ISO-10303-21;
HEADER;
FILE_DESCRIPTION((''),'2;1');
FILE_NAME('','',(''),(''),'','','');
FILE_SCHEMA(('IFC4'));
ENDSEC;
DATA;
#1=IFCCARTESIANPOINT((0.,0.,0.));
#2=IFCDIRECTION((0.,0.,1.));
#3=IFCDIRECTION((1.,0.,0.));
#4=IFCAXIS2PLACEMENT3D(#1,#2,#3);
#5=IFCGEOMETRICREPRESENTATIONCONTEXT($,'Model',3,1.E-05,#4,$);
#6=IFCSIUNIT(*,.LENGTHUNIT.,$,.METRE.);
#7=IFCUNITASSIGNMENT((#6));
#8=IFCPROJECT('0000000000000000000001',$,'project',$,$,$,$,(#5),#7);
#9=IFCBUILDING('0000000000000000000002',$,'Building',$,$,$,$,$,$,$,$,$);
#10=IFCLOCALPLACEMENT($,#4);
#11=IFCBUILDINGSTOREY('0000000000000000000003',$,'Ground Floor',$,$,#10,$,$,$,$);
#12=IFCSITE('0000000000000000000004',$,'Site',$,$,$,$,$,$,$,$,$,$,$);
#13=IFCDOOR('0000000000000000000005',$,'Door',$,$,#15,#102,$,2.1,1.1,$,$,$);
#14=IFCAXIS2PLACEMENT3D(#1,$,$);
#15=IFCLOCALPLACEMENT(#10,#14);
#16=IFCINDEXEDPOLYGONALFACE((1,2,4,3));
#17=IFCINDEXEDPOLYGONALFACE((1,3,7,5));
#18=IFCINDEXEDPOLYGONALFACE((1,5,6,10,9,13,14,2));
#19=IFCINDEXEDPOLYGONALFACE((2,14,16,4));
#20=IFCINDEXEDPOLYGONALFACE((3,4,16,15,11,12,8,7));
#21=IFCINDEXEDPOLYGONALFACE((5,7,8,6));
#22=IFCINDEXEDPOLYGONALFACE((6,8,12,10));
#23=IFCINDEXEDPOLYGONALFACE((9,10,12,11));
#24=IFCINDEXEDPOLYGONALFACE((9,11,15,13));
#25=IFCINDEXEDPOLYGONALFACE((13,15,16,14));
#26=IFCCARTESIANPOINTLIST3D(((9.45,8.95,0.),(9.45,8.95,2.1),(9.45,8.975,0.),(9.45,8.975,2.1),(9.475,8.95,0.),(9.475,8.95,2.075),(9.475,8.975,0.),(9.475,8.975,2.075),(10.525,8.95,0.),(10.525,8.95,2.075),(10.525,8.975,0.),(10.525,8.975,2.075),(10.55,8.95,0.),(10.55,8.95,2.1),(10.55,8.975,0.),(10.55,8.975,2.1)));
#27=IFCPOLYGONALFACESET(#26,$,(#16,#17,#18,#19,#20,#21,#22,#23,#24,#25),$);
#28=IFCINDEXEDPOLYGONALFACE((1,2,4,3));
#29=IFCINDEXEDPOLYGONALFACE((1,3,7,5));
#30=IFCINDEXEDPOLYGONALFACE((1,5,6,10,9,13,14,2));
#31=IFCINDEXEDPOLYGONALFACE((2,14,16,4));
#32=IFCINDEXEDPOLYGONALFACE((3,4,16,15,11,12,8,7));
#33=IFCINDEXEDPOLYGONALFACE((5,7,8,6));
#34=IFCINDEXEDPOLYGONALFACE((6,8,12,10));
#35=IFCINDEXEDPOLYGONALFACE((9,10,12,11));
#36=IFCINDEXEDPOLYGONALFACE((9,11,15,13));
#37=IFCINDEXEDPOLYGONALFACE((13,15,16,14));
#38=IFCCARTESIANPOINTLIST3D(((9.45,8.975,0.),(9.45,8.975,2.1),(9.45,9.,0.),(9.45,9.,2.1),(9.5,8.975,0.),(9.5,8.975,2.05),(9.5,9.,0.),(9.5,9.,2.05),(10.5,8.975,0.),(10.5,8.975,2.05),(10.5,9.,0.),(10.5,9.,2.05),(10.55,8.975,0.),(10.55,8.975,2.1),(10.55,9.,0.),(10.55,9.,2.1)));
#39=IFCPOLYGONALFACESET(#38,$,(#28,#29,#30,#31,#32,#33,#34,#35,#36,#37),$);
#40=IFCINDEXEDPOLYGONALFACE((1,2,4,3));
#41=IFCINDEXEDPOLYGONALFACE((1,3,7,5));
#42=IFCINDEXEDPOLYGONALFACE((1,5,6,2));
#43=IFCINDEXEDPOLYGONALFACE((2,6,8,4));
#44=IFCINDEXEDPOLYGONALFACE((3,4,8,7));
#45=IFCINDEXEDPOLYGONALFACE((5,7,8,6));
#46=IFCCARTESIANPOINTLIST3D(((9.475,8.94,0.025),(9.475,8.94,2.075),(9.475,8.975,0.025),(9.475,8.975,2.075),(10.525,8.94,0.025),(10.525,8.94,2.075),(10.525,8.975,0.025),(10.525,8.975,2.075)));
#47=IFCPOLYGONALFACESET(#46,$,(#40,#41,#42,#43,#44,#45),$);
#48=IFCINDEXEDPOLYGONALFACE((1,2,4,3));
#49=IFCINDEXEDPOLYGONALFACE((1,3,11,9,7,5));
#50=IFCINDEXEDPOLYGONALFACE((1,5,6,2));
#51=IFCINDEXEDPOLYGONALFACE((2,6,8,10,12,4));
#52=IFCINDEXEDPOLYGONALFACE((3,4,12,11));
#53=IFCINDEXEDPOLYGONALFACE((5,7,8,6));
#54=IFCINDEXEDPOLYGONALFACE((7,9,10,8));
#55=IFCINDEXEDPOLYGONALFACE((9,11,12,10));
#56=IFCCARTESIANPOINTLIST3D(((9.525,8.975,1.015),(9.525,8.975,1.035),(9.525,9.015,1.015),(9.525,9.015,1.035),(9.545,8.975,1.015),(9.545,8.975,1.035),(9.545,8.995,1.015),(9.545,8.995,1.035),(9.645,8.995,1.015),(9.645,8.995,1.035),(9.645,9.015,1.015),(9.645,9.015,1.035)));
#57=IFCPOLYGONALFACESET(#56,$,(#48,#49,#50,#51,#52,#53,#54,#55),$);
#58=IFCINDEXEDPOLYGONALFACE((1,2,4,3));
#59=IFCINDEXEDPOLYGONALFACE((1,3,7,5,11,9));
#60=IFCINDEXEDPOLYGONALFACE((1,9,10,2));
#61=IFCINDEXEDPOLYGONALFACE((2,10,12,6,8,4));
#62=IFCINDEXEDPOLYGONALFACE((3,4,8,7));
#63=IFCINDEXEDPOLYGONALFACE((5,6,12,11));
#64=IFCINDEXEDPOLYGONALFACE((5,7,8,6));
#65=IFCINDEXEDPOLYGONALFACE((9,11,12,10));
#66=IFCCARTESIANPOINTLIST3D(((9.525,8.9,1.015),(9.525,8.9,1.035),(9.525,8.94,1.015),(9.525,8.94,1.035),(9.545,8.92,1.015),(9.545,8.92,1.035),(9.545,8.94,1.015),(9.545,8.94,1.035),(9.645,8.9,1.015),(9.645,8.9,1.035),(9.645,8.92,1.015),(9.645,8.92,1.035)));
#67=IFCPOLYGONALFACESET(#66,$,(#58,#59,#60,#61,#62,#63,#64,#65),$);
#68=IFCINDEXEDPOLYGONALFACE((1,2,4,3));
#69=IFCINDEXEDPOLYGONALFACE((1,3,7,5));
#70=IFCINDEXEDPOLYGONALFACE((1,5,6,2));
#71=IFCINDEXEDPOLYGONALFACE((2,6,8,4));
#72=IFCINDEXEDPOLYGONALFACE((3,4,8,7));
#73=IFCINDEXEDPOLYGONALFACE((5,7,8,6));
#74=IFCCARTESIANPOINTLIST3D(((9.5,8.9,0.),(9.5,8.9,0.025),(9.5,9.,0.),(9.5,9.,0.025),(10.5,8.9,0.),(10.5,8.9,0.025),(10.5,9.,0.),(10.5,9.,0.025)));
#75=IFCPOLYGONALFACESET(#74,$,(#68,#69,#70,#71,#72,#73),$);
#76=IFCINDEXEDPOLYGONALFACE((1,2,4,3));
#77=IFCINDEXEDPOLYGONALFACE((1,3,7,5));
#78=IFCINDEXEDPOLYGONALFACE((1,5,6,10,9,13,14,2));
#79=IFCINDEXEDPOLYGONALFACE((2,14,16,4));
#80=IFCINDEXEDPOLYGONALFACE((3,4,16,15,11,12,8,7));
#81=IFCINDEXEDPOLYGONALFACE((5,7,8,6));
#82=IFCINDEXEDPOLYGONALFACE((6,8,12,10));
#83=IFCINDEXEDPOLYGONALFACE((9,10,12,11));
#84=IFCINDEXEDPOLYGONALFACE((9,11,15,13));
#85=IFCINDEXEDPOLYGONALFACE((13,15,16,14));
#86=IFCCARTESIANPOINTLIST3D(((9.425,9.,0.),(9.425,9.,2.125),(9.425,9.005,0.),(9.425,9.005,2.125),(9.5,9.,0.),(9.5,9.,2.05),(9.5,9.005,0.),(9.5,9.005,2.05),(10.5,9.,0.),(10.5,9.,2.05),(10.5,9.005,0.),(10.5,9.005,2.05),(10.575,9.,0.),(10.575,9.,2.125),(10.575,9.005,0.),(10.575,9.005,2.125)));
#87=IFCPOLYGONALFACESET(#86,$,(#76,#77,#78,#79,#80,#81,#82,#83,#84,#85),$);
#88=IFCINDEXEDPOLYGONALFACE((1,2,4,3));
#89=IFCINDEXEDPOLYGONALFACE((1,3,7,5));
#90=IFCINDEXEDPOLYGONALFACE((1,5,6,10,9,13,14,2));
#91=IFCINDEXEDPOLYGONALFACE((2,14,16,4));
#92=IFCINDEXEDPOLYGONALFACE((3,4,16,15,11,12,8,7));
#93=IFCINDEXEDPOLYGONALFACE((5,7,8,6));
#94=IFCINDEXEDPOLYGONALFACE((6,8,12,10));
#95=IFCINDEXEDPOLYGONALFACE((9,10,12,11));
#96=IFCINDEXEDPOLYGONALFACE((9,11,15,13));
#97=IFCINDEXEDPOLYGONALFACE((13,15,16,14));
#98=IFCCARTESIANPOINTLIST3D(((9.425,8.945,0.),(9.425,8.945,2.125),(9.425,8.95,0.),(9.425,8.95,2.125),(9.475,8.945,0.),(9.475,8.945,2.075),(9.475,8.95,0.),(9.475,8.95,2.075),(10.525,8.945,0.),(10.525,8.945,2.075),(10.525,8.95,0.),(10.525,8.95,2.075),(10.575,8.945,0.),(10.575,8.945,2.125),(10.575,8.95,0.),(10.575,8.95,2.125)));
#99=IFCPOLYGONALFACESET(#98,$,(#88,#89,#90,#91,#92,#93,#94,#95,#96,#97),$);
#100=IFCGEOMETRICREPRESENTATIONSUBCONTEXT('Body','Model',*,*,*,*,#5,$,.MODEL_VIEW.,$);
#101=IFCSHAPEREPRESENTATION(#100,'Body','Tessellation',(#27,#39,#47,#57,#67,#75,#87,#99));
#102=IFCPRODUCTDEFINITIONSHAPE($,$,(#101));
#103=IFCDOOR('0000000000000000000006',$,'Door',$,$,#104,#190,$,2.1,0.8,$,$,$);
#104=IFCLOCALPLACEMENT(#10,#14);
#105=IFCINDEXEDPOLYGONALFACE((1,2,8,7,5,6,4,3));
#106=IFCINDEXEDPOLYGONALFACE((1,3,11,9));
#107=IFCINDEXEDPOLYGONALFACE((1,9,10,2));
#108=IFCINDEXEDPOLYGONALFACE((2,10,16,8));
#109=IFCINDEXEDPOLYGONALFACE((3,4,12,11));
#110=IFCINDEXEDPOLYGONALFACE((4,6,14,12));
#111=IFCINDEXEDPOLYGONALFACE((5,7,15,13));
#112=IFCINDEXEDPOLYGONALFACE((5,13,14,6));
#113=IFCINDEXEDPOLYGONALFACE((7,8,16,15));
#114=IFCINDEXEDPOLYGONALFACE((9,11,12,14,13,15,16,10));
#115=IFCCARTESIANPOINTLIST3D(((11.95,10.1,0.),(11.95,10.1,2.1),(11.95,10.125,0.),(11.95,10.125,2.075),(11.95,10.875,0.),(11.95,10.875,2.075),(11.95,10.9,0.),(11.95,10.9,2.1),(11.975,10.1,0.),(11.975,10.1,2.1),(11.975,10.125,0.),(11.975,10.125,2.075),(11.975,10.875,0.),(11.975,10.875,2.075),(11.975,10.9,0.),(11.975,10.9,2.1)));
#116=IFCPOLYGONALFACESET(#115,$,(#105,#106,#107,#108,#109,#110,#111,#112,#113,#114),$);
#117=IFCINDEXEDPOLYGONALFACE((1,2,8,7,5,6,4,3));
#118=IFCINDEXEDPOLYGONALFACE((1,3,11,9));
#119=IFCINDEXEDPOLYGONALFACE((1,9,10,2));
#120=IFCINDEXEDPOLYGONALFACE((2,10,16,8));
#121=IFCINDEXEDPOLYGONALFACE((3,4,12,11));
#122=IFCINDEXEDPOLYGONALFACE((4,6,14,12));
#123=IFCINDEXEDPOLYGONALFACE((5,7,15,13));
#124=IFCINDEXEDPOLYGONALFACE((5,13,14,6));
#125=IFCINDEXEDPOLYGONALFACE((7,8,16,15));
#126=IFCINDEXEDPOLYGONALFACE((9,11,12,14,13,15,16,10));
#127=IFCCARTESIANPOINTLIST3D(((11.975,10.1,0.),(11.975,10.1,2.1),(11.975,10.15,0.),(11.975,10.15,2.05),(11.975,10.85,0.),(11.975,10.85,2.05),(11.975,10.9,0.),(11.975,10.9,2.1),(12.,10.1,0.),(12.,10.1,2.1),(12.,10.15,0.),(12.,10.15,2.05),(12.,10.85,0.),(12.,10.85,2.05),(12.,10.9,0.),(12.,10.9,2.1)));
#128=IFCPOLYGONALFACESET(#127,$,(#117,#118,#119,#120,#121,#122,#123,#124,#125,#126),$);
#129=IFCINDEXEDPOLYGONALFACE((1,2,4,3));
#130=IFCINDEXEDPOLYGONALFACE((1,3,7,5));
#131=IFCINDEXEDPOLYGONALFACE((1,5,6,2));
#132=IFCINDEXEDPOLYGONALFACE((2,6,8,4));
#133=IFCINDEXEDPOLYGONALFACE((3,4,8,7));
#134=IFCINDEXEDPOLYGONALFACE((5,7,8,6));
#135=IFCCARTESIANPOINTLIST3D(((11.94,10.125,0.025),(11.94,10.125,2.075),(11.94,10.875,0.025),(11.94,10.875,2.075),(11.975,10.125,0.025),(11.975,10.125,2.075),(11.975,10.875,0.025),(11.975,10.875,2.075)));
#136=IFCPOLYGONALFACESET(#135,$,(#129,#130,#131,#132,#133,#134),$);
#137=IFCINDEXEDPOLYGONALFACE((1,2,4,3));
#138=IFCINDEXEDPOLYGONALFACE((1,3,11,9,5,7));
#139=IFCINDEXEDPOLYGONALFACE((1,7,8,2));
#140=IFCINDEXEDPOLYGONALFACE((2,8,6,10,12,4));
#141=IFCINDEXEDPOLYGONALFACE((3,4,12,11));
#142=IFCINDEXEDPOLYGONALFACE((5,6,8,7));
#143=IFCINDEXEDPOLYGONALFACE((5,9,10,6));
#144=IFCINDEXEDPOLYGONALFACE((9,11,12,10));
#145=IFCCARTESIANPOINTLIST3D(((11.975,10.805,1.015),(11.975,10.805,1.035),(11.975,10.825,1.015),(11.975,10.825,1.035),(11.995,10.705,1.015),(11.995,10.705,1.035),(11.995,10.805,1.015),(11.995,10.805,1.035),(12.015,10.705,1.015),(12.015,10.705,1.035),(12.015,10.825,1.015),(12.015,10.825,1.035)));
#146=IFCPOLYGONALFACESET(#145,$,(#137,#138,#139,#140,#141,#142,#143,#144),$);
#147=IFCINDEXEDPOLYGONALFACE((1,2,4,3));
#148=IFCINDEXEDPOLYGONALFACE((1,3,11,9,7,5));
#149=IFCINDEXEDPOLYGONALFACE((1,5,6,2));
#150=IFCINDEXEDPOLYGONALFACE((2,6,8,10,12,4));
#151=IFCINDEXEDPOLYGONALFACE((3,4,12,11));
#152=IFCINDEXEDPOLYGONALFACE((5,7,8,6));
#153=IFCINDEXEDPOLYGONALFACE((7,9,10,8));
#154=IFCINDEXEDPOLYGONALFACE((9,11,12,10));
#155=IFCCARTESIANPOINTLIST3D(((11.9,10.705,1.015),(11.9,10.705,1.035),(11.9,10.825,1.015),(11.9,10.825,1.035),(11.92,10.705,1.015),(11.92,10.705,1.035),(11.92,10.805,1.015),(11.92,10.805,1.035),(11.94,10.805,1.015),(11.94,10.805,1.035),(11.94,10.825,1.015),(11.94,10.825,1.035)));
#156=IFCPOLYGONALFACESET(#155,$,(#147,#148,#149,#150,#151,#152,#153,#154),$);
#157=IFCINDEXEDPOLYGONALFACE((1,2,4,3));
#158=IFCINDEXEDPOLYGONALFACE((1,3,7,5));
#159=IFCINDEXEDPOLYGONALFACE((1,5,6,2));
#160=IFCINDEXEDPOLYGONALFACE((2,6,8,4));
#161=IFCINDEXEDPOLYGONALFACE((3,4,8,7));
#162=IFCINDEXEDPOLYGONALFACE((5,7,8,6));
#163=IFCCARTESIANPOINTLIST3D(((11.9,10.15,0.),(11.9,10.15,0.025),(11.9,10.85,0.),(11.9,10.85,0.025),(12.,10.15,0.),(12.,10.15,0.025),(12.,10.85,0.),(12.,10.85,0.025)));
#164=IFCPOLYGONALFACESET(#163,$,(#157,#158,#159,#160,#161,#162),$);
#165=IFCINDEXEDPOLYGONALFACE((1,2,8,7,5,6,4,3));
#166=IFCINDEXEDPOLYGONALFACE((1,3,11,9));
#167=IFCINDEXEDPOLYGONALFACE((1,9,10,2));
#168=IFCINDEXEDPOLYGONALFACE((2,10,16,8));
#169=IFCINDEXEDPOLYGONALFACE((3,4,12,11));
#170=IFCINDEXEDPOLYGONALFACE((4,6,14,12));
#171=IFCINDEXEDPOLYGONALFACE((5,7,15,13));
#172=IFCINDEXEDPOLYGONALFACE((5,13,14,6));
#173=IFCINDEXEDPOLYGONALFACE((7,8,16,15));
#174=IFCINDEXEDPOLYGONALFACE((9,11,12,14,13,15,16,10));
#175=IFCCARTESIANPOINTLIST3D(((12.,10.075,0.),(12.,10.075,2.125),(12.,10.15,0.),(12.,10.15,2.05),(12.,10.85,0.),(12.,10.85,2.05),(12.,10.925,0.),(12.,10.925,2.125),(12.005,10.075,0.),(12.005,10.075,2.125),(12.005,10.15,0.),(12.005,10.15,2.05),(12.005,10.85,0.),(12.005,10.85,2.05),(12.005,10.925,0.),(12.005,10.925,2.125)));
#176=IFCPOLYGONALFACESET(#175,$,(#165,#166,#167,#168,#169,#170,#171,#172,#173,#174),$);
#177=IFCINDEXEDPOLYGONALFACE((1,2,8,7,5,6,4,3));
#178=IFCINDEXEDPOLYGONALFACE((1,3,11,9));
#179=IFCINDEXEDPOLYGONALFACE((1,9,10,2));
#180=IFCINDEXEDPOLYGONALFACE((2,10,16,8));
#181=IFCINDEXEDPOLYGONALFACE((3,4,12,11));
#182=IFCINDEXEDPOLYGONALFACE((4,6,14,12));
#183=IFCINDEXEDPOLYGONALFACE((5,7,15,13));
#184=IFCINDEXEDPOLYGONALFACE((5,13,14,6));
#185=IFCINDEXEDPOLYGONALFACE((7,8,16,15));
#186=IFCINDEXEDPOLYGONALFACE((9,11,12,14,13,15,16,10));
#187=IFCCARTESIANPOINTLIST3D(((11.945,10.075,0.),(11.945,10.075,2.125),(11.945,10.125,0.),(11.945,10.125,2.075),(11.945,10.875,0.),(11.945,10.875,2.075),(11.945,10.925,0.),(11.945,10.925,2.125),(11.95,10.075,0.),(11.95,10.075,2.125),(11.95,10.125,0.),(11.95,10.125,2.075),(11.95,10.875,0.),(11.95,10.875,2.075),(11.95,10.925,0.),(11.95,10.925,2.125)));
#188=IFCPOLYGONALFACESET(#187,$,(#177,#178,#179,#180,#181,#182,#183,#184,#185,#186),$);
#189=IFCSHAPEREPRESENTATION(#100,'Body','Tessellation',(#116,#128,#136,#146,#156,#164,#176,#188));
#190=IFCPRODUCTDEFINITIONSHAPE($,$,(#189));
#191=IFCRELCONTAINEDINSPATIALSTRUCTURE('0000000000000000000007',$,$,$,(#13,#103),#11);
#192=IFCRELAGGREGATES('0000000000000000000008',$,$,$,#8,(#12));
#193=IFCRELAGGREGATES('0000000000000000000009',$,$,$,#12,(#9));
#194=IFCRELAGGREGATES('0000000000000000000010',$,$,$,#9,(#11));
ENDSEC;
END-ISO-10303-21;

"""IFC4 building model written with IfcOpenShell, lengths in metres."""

from ifc_helpers import new_model, si_unit, frame, origin_with_axes, place, context, subcontext, project, spatial, line, indexed_curve, outline, extrude, element, save


model = new_model("IFC4")

# Units and contexts
model_context = context("Model", 3, precision=1e-05, world=origin_with_axes())
body_context = subcontext(model_context, "Body", "Model", "MODEL_VIEW")
ifc_project = project(units=[si_unit("LENGTHUNIT", "METRE")], contexts=[model_context])

# Site, building, storey
site = spatial("IfcSite", under=ifc_project, Name="Site")
building = spatial("IfcBuilding", under=site, Name="Building")
storey_placement = place(None, origin_with_axes())
storey = spatial("IfcBuildingStorey", under=building, at=storey_placement, Name="Ground Floor")

# Doors
door_1_placement = place(storey_placement, frame((10.55, 9.0, 0.0), z_axis=(0.0, 0.0, 1.0), x_axis=(-1.0, 0.0, 0.0)))
element("IfcDoor", 1, at=door_1_placement, inside=storey, Name="Door", OverallHeight=2.1, OverallWidth=1.1, context=body_context, shape_type="SweptSolid", body=[
    extrude(outline(indexed_curve([(0.0, 0.0), (0.0, 2.1), (1.1, 2.1), (1.1, 0.0), (1.075, 0.0), (1.075, 2.075), (0.025, 2.075), (0.025, 0.0)], segments=[line(1, 2, 3, 4, 5, 6, 7, 8, 1)])), frame((0.0, 0.025, 0.0), z_axis=(0.0, -1.0, 0.0), x_axis=(1.0, 0.0, 0.0)), (0.0, 0.0, -1.0), 0.025),
    extrude(outline(indexed_curve([(0.0, 0.0), (0.0, 2.1), (1.1, 2.1), (1.1, 0.0), (1.05, 0.0), (1.05, 2.05), (0.05, 2.05), (0.05, 0.0)], segments=[line(1, 2, 3, 4, 5, 6, 7, 8, 1)])), frame((0.0, 0.0, 0.0), z_axis=(0.0, -1.0, 0.0), x_axis=(1.0, 0.0, 0.0)), (0.0, 0.0, -1.0), 0.025),
    extrude(outline(indexed_curve([(0.0, 0.0), (1.05, 0.0), (1.05, 0.035), (0.0, 0.035)], segments=[line(1, 2, 3, 4, 1)])), frame((0.025, 0.025, 0.025), z_axis=(0.0, 0.0, 1.0), x_axis=(1.0, 0.0, 0.0)), (0.0, 0.0, 1.0), 2.05),
    extrude(outline(indexed_curve([(0.0, 0.0), (0.0, -0.04), (-0.12, -0.04), (-0.12, -0.02), (-0.02, -0.02), (-0.02, 0.0)], segments=[line(1, 2, 3, 4, 5, 6, 1)])), frame((1.025, 0.025, 1.015), z_axis=(0.0, 0.0, 1.0), x_axis=(1.0, 0.0, 0.0)), (0.0, 0.0, 1.0), 0.02),
    extrude(outline(indexed_curve([(0.0, 0.0), (0.0, 0.04), (-0.12, 0.04), (-0.12, 0.02), (-0.02, 0.02), (-0.02, 0.0)], segments=[line(1, 2, 3, 4, 5, 6, 1)])), frame((1.025, 0.06, 1.015), z_axis=(0.0, 0.0, 1.0), x_axis=(1.0, 0.0, 0.0)), (0.0, 0.0, 1.0), 0.02),
    extrude(outline(indexed_curve([(0.0, 0.0), (1.0, 0.0), (1.0, 0.1), (0.0, 0.1)], segments=[line(1, 2, 3, 4, 1)])), frame((0.05, 0.0, 0.0), z_axis=(0.0, 0.0, 1.0), x_axis=(1.0, 0.0, 0.0)), (0.0, 0.0, 1.0), 0.025),
    extrude(outline(indexed_curve([(0.0, 0.0), (0.0, 2.125), (1.15, 2.125), (1.15, 0.0), (1.075, 0.0), (1.075, 2.05), (0.075, 2.05), (0.075, 0.0)], segments=[line(1, 2, 3, 4, 5, 6, 7, 8, 1)])), frame((-0.025, -0.005, 0.0), z_axis=(0.0, -1.0, 0.0), x_axis=(1.0, 0.0, 0.0)), (0.0, 0.0, -1.0), 0.005),
    extrude(outline(indexed_curve([(0.0, 0.0), (0.0, 2.125), (1.15, 2.125), (1.15, 0.0), (1.1, 0.0), (1.1, 2.075), (0.05, 2.075), (0.05, 0.0)], segments=[line(1, 2, 3, 4, 5, 6, 7, 8, 1)])), frame((-0.025, 0.05, 0.0), z_axis=(0.0, -1.0, 0.0), x_axis=(1.0, 0.0, 0.0)), (0.0, 0.0, -1.0), 0.005),
])
door_2_placement = place(storey_placement, frame((12.0, 10.1, 0.0), z_axis=(0.0, 0.0, 1.0), x_axis=(0.0, 1.0, 0.0)))
element("IfcDoor", 2, at=door_2_placement, inside=storey, Name="Door", OverallHeight=2.1, OverallWidth=0.8, context=body_context, shape_type="SweptSolid", body=[
    extrude(outline(indexed_curve([(0.0, 0.0), (0.0, 2.1), (0.8, 2.1), (0.8, 0.0), (0.775, 0.0), (0.775, 2.075), (0.025, 2.075), (0.025, 0.0)], segments=[line(1, 2, 3, 4, 5, 6, 7, 8, 1)])), frame((0.0, 0.025, 0.0), z_axis=(0.0, -1.0, 0.0), x_axis=(1.0, 0.0, 0.0)), (0.0, 0.0, -1.0), 0.025),
    extrude(outline(indexed_curve([(0.0, 0.0), (0.0, 2.1), (0.8, 2.1), (0.8, 0.0), (0.75, 0.0), (0.75, 2.05), (0.05, 2.05), (0.05, 0.0)], segments=[line(1, 2, 3, 4, 5, 6, 7, 8, 1)])), frame((0.0, 0.0, 0.0), z_axis=(0.0, -1.0, 0.0), x_axis=(1.0, 0.0, 0.0)), (0.0, 0.0, -1.0), 0.025),
    extrude(outline(indexed_curve([(0.0, 0.0), (0.75, 0.0), (0.75, 0.035), (0.0, 0.035)], segments=[line(1, 2, 3, 4, 1)])), frame((0.025, 0.025, 0.025), z_axis=(0.0, 0.0, 1.0), x_axis=(1.0, 0.0, 0.0)), (0.0, 0.0, 1.0), 2.05),
    extrude(outline(indexed_curve([(0.0, 0.0), (0.0, -0.04), (-0.12, -0.04), (-0.12, -0.02), (-0.02, -0.02), (-0.02, 0.0)], segments=[line(1, 2, 3, 4, 5, 6, 1)])), frame((0.725, 0.025, 1.015), z_axis=(0.0, 0.0, 1.0), x_axis=(1.0, 0.0, 0.0)), (0.0, 0.0, 1.0), 0.02),
    extrude(outline(indexed_curve([(0.0, 0.0), (0.0, 0.04), (-0.12, 0.04), (-0.12, 0.02), (-0.02, 0.02), (-0.02, 0.0)], segments=[line(1, 2, 3, 4, 5, 6, 1)])), frame((0.725, 0.06, 1.015), z_axis=(0.0, 0.0, 1.0), x_axis=(1.0, 0.0, 0.0)), (0.0, 0.0, 1.0), 0.02),
    extrude(outline(indexed_curve([(0.0, 0.0), (0.7, 0.0), (0.7, 0.1), (0.0, 0.1)], segments=[line(1, 2, 3, 4, 1)])), frame((0.05, 0.0, 0.0), z_axis=(0.0, 0.0, 1.0), x_axis=(1.0, 0.0, 0.0)), (0.0, 0.0, 1.0), 0.025),
    extrude(outline(indexed_curve([(0.0, 0.0), (0.0, 2.125), (0.85, 2.125), (0.85, 0.0), (0.775, 0.0), (0.775, 2.05), (0.075, 2.05), (0.075, 0.0)], segments=[line(1, 2, 3, 4, 5, 6, 7, 8, 1)])), frame((-0.025, -0.005, 0.0), z_axis=(0.0, -1.0, 0.0), x_axis=(1.0, 0.0, 0.0)), (0.0, 0.0, -1.0), 0.005),
    extrude(outline(indexed_curve([(0.0, 0.0), (0.0, 2.125), (0.85, 2.125), (0.85, 0.0), (0.8, 0.0), (0.8, 2.075), (0.05, 2.075), (0.05, 0.0)], segments=[line(1, 2, 3, 4, 5, 6, 7, 8, 1)])), frame((-0.025, 0.05, 0.0), z_axis=(0.0, -1.0, 0.0), x_axis=(1.0, 0.0, 0.0)), (0.0, 0.0, -1.0), 0.005),
])

save(model, "model.ifc")
